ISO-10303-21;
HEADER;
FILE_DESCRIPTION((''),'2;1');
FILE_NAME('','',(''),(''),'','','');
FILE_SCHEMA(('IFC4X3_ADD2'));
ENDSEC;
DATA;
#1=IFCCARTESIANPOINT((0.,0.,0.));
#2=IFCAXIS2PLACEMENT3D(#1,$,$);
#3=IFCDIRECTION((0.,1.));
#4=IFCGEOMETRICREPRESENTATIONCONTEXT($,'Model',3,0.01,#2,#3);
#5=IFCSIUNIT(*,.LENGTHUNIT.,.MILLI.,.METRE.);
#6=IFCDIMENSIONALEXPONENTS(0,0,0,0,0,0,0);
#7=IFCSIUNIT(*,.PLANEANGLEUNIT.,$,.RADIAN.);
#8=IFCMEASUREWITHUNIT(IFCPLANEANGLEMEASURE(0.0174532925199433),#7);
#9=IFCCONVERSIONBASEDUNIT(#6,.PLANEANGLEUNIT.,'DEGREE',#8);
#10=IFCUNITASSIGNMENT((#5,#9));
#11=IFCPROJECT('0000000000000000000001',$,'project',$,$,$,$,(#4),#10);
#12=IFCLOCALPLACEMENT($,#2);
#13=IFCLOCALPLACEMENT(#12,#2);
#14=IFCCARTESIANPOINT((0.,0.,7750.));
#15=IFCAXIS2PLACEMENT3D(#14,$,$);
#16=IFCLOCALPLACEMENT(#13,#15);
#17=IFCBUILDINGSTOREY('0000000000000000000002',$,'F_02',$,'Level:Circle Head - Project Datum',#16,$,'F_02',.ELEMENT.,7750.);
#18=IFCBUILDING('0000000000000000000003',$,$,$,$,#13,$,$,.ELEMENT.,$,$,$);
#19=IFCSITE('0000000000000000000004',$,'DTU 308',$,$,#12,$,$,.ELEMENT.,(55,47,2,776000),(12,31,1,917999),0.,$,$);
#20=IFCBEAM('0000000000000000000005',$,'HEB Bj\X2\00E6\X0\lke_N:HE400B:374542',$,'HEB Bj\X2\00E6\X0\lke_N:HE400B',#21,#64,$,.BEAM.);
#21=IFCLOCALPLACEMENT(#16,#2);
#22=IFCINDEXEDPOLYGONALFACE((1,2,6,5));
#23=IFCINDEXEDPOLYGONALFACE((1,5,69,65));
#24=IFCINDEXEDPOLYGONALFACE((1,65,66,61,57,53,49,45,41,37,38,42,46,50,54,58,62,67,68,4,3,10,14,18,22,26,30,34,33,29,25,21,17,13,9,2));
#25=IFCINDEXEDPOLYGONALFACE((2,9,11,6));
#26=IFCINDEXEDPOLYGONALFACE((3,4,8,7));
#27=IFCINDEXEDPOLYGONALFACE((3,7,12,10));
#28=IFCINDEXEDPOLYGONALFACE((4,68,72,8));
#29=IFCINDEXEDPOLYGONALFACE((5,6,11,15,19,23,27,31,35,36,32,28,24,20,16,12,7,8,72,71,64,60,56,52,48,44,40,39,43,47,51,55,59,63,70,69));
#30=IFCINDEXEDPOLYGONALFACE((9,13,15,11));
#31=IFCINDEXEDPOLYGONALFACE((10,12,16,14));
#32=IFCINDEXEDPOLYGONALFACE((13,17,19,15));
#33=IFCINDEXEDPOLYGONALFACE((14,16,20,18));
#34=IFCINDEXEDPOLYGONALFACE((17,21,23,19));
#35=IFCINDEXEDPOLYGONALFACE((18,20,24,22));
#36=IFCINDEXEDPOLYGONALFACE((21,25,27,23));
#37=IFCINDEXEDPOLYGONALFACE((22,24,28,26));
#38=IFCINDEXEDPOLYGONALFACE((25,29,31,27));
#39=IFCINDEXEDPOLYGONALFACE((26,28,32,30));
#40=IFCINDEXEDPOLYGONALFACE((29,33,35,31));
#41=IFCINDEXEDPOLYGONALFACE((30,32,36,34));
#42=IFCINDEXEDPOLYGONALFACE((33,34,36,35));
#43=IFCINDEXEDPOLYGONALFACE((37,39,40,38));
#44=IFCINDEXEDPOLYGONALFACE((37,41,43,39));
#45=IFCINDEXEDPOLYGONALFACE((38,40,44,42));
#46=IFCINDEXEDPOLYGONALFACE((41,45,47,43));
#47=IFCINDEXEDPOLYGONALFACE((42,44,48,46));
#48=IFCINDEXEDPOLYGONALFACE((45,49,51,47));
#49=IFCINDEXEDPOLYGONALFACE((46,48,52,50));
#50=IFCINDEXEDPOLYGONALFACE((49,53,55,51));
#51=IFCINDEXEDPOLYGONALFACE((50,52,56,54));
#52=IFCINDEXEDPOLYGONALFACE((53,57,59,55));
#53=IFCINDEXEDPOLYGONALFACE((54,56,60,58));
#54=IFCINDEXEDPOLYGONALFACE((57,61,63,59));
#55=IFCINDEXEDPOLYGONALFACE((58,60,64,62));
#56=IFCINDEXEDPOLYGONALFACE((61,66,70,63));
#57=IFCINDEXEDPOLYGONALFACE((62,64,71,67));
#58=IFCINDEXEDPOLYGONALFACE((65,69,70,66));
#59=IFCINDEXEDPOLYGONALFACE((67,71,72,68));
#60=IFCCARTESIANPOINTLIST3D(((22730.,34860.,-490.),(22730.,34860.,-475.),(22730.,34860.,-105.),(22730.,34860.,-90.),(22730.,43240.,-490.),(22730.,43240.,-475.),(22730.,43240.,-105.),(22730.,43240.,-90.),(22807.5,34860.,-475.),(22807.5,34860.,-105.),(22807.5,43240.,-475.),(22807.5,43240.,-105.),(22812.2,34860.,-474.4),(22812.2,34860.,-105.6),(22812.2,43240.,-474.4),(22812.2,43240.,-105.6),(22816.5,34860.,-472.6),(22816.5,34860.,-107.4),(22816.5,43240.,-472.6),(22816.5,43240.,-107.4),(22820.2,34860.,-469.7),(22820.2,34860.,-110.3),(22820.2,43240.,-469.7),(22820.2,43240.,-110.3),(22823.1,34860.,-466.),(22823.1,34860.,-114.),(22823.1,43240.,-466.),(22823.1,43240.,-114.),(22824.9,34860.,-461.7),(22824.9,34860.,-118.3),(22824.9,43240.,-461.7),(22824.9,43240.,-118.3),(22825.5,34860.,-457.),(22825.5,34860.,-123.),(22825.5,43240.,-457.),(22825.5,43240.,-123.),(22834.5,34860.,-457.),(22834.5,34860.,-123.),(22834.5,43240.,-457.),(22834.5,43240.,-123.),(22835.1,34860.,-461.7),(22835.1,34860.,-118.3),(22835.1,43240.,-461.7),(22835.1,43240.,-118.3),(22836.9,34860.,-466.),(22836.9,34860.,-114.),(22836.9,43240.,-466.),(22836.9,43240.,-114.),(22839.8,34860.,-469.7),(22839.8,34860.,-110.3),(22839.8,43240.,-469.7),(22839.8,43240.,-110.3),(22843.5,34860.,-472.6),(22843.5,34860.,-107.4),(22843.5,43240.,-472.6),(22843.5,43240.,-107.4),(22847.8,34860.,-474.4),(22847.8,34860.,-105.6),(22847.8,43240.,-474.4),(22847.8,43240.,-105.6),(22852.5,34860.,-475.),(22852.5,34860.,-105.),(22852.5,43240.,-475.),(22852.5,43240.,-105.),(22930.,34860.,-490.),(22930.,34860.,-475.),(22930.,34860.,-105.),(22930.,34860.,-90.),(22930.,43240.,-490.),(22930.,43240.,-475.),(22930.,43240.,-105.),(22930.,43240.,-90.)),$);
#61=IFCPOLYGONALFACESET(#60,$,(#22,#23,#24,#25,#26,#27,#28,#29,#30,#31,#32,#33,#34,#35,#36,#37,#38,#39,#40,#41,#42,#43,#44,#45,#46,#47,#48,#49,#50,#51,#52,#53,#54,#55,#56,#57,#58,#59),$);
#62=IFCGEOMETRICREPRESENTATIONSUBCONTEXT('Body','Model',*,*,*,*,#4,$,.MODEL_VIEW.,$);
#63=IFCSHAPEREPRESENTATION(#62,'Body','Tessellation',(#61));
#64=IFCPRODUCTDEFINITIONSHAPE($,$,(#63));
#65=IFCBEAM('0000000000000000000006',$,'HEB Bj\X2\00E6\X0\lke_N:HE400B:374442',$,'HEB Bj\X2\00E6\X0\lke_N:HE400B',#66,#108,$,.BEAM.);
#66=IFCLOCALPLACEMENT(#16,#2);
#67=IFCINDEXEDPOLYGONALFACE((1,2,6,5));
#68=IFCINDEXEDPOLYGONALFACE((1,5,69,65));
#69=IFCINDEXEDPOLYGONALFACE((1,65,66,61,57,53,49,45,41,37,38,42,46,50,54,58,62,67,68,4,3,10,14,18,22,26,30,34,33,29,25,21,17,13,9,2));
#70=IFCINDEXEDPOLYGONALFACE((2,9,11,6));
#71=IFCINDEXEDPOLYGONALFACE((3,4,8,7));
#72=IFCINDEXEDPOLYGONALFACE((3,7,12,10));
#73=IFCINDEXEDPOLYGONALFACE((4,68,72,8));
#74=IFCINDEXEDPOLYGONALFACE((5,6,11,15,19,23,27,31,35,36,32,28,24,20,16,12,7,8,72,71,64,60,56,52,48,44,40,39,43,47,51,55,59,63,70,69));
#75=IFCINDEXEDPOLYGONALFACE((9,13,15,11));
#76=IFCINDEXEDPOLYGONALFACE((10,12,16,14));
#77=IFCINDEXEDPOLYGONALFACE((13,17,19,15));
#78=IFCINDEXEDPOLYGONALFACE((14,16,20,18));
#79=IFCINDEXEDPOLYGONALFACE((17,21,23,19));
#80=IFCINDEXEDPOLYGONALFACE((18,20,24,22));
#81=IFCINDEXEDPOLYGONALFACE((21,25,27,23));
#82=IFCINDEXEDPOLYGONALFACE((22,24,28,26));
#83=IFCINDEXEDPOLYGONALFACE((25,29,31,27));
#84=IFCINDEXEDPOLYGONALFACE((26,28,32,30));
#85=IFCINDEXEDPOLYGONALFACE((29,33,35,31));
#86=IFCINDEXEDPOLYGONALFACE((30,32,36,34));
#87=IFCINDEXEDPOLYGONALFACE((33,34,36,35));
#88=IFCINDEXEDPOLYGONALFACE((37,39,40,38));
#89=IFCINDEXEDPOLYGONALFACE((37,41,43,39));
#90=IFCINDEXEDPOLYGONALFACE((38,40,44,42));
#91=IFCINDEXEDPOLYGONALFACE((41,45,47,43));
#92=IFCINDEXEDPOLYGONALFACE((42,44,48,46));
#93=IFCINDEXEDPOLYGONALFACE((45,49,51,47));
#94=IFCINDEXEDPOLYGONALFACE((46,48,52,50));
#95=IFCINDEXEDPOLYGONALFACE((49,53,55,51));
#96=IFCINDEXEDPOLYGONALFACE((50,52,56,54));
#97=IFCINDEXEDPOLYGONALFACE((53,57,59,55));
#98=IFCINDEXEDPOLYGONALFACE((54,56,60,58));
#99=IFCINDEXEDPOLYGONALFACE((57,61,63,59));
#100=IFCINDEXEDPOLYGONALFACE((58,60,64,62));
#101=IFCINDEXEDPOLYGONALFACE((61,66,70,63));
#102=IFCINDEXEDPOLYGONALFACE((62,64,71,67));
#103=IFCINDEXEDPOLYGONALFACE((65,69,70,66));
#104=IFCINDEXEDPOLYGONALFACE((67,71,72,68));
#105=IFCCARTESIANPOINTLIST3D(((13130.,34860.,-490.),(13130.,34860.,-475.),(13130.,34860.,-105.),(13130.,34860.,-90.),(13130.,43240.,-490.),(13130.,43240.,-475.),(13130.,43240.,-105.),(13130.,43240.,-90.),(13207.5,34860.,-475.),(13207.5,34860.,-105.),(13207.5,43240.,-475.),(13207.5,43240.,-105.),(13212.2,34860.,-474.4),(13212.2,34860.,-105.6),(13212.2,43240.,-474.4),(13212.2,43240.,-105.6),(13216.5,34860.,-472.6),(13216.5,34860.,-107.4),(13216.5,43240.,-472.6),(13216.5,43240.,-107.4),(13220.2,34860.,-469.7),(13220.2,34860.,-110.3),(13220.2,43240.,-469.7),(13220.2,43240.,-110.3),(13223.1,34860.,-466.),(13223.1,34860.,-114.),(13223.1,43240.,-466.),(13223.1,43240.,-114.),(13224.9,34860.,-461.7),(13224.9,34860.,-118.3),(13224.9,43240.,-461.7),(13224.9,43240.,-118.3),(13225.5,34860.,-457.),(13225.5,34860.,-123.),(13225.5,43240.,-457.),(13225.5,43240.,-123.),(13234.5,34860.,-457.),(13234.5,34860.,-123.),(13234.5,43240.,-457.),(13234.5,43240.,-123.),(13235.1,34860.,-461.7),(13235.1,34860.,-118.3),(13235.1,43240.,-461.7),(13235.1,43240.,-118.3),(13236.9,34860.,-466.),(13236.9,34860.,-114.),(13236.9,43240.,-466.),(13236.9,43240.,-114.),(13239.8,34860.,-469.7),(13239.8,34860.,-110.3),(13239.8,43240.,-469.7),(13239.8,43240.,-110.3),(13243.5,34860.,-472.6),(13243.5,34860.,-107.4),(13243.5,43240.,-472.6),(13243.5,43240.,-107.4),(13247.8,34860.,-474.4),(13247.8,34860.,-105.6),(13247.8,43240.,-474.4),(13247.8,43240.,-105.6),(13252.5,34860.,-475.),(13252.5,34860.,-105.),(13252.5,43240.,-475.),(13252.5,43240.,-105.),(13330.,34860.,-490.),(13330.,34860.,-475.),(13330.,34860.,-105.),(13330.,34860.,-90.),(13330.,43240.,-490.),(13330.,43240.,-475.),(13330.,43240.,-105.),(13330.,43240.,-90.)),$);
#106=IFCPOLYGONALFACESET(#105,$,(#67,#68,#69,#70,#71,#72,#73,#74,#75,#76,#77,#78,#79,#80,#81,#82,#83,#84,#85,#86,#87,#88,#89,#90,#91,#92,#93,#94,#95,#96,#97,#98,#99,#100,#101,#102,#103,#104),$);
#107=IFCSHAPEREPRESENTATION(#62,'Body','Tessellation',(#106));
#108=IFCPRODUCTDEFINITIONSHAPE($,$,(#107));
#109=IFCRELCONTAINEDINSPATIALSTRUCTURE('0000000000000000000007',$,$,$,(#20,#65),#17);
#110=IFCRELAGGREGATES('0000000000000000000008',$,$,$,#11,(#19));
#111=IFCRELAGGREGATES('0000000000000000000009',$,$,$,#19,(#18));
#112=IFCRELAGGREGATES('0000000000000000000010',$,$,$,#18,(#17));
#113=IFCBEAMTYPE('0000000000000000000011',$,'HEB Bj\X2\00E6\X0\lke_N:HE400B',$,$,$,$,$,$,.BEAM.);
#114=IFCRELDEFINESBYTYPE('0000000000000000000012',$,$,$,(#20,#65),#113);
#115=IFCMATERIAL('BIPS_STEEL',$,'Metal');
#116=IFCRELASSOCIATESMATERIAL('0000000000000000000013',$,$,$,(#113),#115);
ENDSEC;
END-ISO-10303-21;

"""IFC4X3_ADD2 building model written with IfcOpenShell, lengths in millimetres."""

from ifc_helpers import new_model, entity, si_unit, converted_unit, direction, frame, frame_2d, origin, place, context, subcontext, project, spatial, polyline, circle_curve, parameter, trimmed, segment, composite_curve, outline, extrude, source, transform, mapped, material, material_profile, profile_set, type_object, element, save


model = new_model("IFC4X3_ADD2")

# Units and contexts
model_context = context("Model", 3, precision=0.01, world=origin(), true_north=direction((0.0, 1.0)))
body_context = subcontext(model_context, "Body", "Model", "MODEL_VIEW")
ifc_project = project(units=[si_unit("LENGTHUNIT", "METRE", prefix="MILLI"), converted_unit("PLANEANGLEUNIT", "DEGREE", entity("IfcPlaneAngleMeasure", 0.0174532925199433), si_unit("PLANEANGLEUNIT", "RADIAN"), dimensions=[0, 0, 0, 0, 0, 0, 0])], contexts=[model_context])

# Site, building, storey
site_placement = place(None, origin())
site = spatial("IfcSite", under=ifc_project, at=site_placement, Name="DTU 308", CompositionType="ELEMENT", RefLatitude=(55, 47, 2, 776000), RefLongitude=(12, 31, 1, 917999), RefElevation=0.0)
building_placement = place(site_placement, origin())
building = spatial("IfcBuilding", under=site, at=building_placement, CompositionType="ELEMENT")
storey_placement = place(building_placement, frame((0.0, 0.0, 7750.0)))
storey = spatial("IfcBuildingStorey", under=building, at=storey_placement, Name="F_02", ObjectType="Level:Circle Head - Project Datum", LongName="F_02", CompositionType="ELEMENT", Elevation=7750.0)

# Shared definitions
ifc_material = material(Name="BIPS_STEEL", Category="Metal")

# Beams
ifc_material_profile_1 = material_profile(ifc_material, outline(composite_curve([segment(polyline([(-100.0, -185.0), (-100.0, -200.0)]), True, "CONTINUOUS"), segment(polyline([(-100.0, -200.0), (100.0, -200.0)]), True, "CONTINUOUS"), segment(polyline([(100.0, -200.0), (100.0, -185.0)]), True, "CONTINUOUS"), segment(polyline([(100.0, -185.0), (22.5, -185.0)]), True, "CONTINUOUS"), segment(trimmed(circle_curve(frame_2d((22.5, -167.0), x_axis=(1.0, 0.0)), 18.0), [parameter(180.0)], [parameter(270.0)], True, "PARAMETER"), False, "CONTINUOUS"), segment(polyline([(4.5, -167.0), (4.5, 167.0)]), True, "CONTINUOUS"), segment(trimmed(circle_curve(frame_2d((22.5, 167.0), x_axis=(1.0, 0.0)), 18.0), [parameter(90.0)], [parameter(180.0)], True, "PARAMETER"), False, "CONTINUOUS"), segment(polyline([(22.5, 185.0), (100.0, 185.0)]), True, "CONTINUOUS"), segment(polyline([(100.0, 185.0), (100.0, 200.0)]), True, "CONTINUOUS"), segment(polyline([(100.0, 200.0), (-100.0, 200.0)]), True, "CONTINUOUS"), segment(polyline([(-100.0, 200.0), (-100.0, 185.0)]), True, "CONTINUOUS"), segment(polyline([(-100.0, 185.0), (-22.5, 185.0)]), True, "CONTINUOUS"), segment(trimmed(circle_curve(frame_2d((-22.5, 167.0), x_axis=(1.0, 0.0)), 18.0), [parameter(360.0)], [parameter(90.0)], True, "PARAMETER"), False, "CONTINUOUS"), segment(polyline([(-4.5, 167.0), (-4.5, -167.0)]), True, "CONTINUOUS"), segment(trimmed(circle_curve(frame_2d((-22.5, -167.0), x_axis=(1.0, 0.0)), 18.0), [parameter(270.0)], [parameter(360.0)], True, "PARAMETER"), False, "CONTINUOUS"), segment(polyline([(-22.5, -185.0), (-100.0, -185.0)]), True, "CONTINUOUS")], self_intersect=False)), Name="HE400B")
ifc_profile_set_1 = profile_set([ifc_material_profile_1], Name="HE400B")
beam_type_1 = type_object("IfcBeamType", Name="HEB Bjælke_N:HE400B", PredefinedType="BEAM", material=ifc_profile_set_1)
shared_shape_1 = source(origin(), body_context, "Body", "SweptSolid", [
    extrude(outline(composite_curve([segment(polyline([(-100.0, -185.0), (-100.0, -200.0)]), True, "CONTINUOUS"), segment(polyline([(-100.0, -200.0), (100.0, -200.0)]), True, "CONTINUOUS"), segment(polyline([(100.0, -200.0), (100.0, -185.0)]), True, "CONTINUOUS"), segment(polyline([(100.0, -185.0), (22.5, -185.0)]), True, "CONTINUOUS"), segment(trimmed(circle_curve(frame_2d((22.5, -167.0), x_axis=(1.0, 0.0)), 18.0), [parameter(180.0)], [parameter(270.0)], True, "PARAMETER"), False, "CONTINUOUS"), segment(polyline([(4.5, -167.0), (4.5, 167.0)]), True, "CONTINUOUS"), segment(trimmed(circle_curve(frame_2d((22.5, 167.0), x_axis=(1.0, 0.0)), 18.0), [parameter(90.0)], [parameter(180.0)], True, "PARAMETER"), False, "CONTINUOUS"), segment(polyline([(22.5, 185.0), (100.0, 185.0)]), True, "CONTINUOUS"), segment(polyline([(100.0, 185.0), (100.0, 200.0)]), True, "CONTINUOUS"), segment(polyline([(100.0, 200.0), (-100.0, 200.0)]), True, "CONTINUOUS"), segment(polyline([(-100.0, 200.0), (-100.0, 185.0)]), True, "CONTINUOUS"), segment(polyline([(-100.0, 185.0), (-22.5, 185.0)]), True, "CONTINUOUS"), segment(trimmed(circle_curve(frame_2d((-22.5, 167.0), x_axis=(1.0, 0.0)), 18.0), [parameter(360.0)], [parameter(90.0)], True, "PARAMETER"), False, "CONTINUOUS"), segment(polyline([(-4.5, 167.0), (-4.5, -167.0)]), True, "CONTINUOUS"), segment(trimmed(circle_curve(frame_2d((-22.5, -167.0), x_axis=(1.0, 0.0)), 18.0), [parameter(270.0)], [parameter(360.0)], True, "PARAMETER"), False, "CONTINUOUS"), segment(polyline([(-22.5, -185.0), (-100.0, -185.0)]), True, "CONTINUOUS")], self_intersect=False)), frame((-5880.0, 0.0, 0.0), z_axis=(-1.0, 0.0, 0.0), x_axis=(0.0, -1.0, 0.0)), (0.0, 0.0, -1.0), 8380.0),
])
for number, where, z_axis, x_axis, name in (
    (1, (22830.0, 37360.0, -290.0), (0.0, 0.0, 1.0), (0.0, -1.0, 0.0), "HEB Bjælke_N:HE400B:374542"),
):
    element("IfcBeam", number, at=place(storey_placement, frame(where, z_axis=z_axis, x_axis=x_axis)), inside=storey, type_object=beam_type_1, Name=name, ObjectType="HEB Bjælke_N:HE400B", PredefinedType="BEAM", context=body_context, shape_type="MappedRepresentation", body=[
        mapped(shared_shape_1, transform((0.0, 0.0, 0.0), scale=1.0)),
    ])
shared_shape_2 = source(origin(), body_context, "Body", "SweptSolid", [
    extrude(outline(composite_curve([segment(polyline([(-100.0, -185.0), (-100.0, -200.0)]), True, "CONTINUOUS"), segment(polyline([(-100.0, -200.0), (100.0, -200.0)]), True, "CONTINUOUS"), segment(polyline([(100.0, -200.0), (100.0, -185.0)]), True, "CONTINUOUS"), segment(polyline([(100.0, -185.0), (22.5, -185.0)]), True, "CONTINUOUS"), segment(trimmed(circle_curve(frame_2d((22.5, -167.0), x_axis=(1.0, 0.0)), 18.0), [parameter(180.0)], [parameter(270.0)], True, "PARAMETER"), False, "CONTINUOUS"), segment(polyline([(4.5, -167.0), (4.5, 167.0)]), True, "CONTINUOUS"), segment(trimmed(circle_curve(frame_2d((22.5, 167.0), x_axis=(1.0, 0.0)), 18.0), [parameter(90.0)], [parameter(180.0)], True, "PARAMETER"), False, "CONTINUOUS"), segment(polyline([(22.5, 185.0), (100.0, 185.0)]), True, "CONTINUOUS"), segment(polyline([(100.0, 185.0), (100.0, 200.0)]), True, "CONTINUOUS"), segment(polyline([(100.0, 200.0), (-100.0, 200.0)]), True, "CONTINUOUS"), segment(polyline([(-100.0, 200.0), (-100.0, 185.0)]), True, "CONTINUOUS"), segment(polyline([(-100.0, 185.0), (-22.5, 185.0)]), True, "CONTINUOUS"), segment(trimmed(circle_curve(frame_2d((-22.5, 167.0), x_axis=(1.0, 0.0)), 18.0), [parameter(360.0)], [parameter(90.0)], True, "PARAMETER"), False, "CONTINUOUS"), segment(polyline([(-4.5, 167.0), (-4.5, -167.0)]), True, "CONTINUOUS"), segment(trimmed(circle_curve(frame_2d((-22.5, -167.0), x_axis=(1.0, 0.0)), 18.0), [parameter(270.0)], [parameter(360.0)], True, "PARAMETER"), False, "CONTINUOUS"), segment(polyline([(-22.5, -185.0), (-100.0, -185.0)]), True, "CONTINUOUS")], self_intersect=False)), frame((-2500.0, 0.0, 0.0), z_axis=(-1.0, 0.0, 0.0), x_axis=(0.0, -1.0, 0.0)), (0.0, 0.0, -1.0), 8380.0),
])
beam_1_placement = place(storey_placement, frame((13230.0, 37360.0, -290.0), z_axis=(0.0, 0.0, 1.0), x_axis=(0.0, 1.0, 0.0)))
element("IfcBeam", 2, at=beam_1_placement, inside=storey, type_object=beam_type_1, Name="HEB Bjælke_N:HE400B:374442", ObjectType="HEB Bjælke_N:HE400B", PredefinedType="BEAM", context=body_context, shape_type="MappedRepresentation", body=[
    mapped(shared_shape_2, transform((0.0, 0.0, 0.0), scale=1.0)),
])

save(model, "model.ifc")
